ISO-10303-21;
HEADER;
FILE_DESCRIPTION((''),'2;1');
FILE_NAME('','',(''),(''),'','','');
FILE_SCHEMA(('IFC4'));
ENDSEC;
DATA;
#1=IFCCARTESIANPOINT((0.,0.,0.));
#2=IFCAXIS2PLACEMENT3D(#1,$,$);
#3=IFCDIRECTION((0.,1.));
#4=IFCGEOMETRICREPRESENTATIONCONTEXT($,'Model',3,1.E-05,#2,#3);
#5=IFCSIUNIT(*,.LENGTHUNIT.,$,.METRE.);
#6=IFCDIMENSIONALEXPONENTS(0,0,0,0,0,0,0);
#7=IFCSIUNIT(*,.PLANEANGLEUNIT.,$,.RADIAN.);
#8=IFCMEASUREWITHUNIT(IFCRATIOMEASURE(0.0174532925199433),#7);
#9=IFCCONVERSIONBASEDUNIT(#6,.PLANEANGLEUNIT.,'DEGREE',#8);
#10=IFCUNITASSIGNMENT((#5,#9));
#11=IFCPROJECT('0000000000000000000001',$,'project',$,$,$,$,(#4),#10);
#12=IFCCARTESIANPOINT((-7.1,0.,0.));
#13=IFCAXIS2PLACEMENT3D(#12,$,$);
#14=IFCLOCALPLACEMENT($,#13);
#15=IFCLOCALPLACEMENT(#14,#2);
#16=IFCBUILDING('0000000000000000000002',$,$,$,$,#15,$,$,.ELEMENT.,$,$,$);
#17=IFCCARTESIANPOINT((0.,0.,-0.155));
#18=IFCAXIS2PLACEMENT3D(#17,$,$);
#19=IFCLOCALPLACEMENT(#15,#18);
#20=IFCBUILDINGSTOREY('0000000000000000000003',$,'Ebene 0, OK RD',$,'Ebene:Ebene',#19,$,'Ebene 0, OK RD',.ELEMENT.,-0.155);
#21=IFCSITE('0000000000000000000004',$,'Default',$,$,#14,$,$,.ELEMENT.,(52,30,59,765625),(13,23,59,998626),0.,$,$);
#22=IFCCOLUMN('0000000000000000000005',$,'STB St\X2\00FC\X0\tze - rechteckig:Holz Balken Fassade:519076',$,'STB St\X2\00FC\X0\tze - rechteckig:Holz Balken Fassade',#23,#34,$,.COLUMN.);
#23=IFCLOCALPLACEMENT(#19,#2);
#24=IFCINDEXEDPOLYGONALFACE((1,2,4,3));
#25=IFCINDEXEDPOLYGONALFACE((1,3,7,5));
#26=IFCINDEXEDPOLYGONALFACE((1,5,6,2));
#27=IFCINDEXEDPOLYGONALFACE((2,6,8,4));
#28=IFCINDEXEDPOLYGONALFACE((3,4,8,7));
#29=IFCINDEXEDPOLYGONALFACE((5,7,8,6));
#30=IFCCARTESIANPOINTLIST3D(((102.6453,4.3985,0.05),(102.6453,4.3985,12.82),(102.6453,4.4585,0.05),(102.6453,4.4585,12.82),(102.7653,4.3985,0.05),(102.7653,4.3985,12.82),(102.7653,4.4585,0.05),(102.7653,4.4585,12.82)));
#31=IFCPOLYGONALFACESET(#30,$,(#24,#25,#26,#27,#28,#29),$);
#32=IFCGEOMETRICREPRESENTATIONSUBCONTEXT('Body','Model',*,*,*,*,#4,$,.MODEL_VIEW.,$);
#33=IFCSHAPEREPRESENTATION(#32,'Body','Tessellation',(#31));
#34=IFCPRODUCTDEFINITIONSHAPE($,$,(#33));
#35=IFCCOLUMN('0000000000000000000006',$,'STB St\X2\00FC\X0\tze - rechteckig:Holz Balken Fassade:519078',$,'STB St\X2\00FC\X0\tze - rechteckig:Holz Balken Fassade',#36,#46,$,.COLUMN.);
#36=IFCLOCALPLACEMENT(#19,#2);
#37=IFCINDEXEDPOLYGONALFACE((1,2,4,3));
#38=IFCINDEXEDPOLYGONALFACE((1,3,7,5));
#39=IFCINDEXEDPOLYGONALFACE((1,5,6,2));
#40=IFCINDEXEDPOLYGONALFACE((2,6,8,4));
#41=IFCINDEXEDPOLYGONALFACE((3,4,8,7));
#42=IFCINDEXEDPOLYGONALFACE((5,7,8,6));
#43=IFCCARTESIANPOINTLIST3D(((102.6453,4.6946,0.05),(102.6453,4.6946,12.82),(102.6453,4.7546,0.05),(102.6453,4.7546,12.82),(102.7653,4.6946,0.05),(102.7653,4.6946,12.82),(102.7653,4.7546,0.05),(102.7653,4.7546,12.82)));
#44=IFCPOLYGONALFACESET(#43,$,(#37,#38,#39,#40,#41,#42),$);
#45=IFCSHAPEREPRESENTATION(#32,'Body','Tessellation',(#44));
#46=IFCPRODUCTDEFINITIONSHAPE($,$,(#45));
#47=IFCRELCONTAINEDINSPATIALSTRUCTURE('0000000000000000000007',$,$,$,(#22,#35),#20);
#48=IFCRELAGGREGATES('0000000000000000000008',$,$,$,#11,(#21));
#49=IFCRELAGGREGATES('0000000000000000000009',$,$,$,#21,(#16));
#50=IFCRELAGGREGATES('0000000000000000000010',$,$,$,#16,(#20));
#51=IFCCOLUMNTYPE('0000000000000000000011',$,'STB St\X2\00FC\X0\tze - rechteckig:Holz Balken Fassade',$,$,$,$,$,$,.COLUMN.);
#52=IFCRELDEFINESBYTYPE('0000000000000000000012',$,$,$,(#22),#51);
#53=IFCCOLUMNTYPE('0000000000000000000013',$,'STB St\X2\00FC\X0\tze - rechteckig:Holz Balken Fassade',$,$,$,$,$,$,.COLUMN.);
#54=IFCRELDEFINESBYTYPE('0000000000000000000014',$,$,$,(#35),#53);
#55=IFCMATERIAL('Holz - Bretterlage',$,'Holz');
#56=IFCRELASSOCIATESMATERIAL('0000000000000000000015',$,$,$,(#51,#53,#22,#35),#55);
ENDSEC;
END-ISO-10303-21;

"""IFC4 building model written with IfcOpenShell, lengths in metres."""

from ifc_helpers import new_model, entity, si_unit, converted_unit, direction, frame, frame_2d, origin, place, context, subcontext, project, spatial, rectangle, extrude, source, transform, mapped, material, material_profile, profile_set, profile_usage, type_object, type_shapes, element, save


model = new_model("IFC4")

# Units and contexts
model_context = context("Model", 3, precision=1e-05, world=origin(), true_north=direction((0.0, 1.0)))
body_context = subcontext(model_context, "Body", "Model", "MODEL_VIEW")
ifc_project = project(units=[si_unit("LENGTHUNIT", "METRE"), converted_unit("PLANEANGLEUNIT", "DEGREE", entity("IfcRatioMeasure", 0.0174532925199433), si_unit("PLANEANGLEUNIT", "RADIAN"), dimensions=[0, 0, 0, 0, 0, 0, 0])], contexts=[model_context])

# Site, building, storey
site_placement = place(None, frame((-7.1, 0.0, 0.0)))
site = spatial("IfcSite", under=ifc_project, at=site_placement, Name="Default", CompositionType="ELEMENT", RefLatitude=(52, 30, 59, 765625), RefLongitude=(13, 23, 59, 998626), RefElevation=0.0)
building_placement = place(site_placement, origin())
building = spatial("IfcBuilding", under=site, at=building_placement, CompositionType="ELEMENT")
storey_placement = place(building_placement, frame((0.0, 0.0, -0.155)))
storey = spatial("IfcBuildingStorey", under=building, at=storey_placement, Name="Ebene 0, OK RD", ObjectType="Ebene:Ebene", LongName="Ebene 0, OK RD", CompositionType="ELEMENT", Elevation=-0.155)

# Columns
ifc_material = material(Name="Holz - Bretterlage", Category="Holz")
ifc_material_profile = material_profile(ifc_material, rectangle(XDim=0.12, YDim=0.06, at=frame_2d((0.0, 0.0), x_axis=(1.0, 0.0))), Name="Holz Balken Fassade")
ifc_profile_set = profile_set([ifc_material_profile], Name="Holz Balken Fassade")
ifc_profile_usage_1 = profile_usage(ifc_profile_set)
column_type_1 = type_object("IfcColumnType", Name="STB Stütze - rechteckig:Holz Balken Fassade", PredefinedType="COLUMN", material=ifc_profile_set)
shared_shape_1 = source(origin(), body_context, "Body", "SweptSolid", [
    extrude(rectangle(XDim=0.06, YDim=0.12, at=frame_2d((0.0, 0.0), x_axis=(1.0, 0.0))), frame((102.7053, 4.4285, -0.105), z_axis=(0.0, 0.0, 1.0), x_axis=(0.0, -1.0, 0.0)), (0.0, 0.0, 1.0), 12.77),
])
type_shapes(column_type_1, [shared_shape_1])
column_1_placement = place(storey_placement, frame((0.0, 0.0, 0.155)))
element("IfcColumn", 1, at=column_1_placement, inside=storey, type_object=column_type_1, material=ifc_profile_usage_1, Name="STB Stütze - rechteckig:Holz Balken Fassade:519076", ObjectType="STB Stütze - rechteckig:Holz Balken Fassade", PredefinedType="COLUMN", context=body_context, shape_type="MappedRepresentation", body=[
    mapped(shared_shape_1, transform((0.0, 0.0, 0.0), scale=1.0)),
])
ifc_profile_usage_2 = profile_usage(ifc_profile_set)
column_type_2 = type_object("IfcColumnType", Name="STB Stütze - rechteckig:Holz Balken Fassade", PredefinedType="COLUMN", material=ifc_profile_set)
shared_shape_2 = source(origin(), body_context, "Body", "SweptSolid", [
    extrude(rectangle(XDim=0.06, YDim=0.12, at=frame_2d((0.0, 0.0), x_axis=(1.0, 0.0))), frame((102.7053, 4.7246, -0.105), z_axis=(0.0, 0.0, 1.0), x_axis=(0.0, -1.0, 0.0)), (0.0, 0.0, 1.0), 12.77),
])
type_shapes(column_type_2, [shared_shape_2])
column_2_placement = place(storey_placement, frame((0.0, 0.0, 0.155)))
element("IfcColumn", 2, at=column_2_placement, inside=storey, type_object=column_type_2, material=ifc_profile_usage_2, Name="STB Stütze - rechteckig:Holz Balken Fassade:519078", ObjectType="STB Stütze - rechteckig:Holz Balken Fassade", PredefinedType="COLUMN", context=body_context, shape_type="MappedRepresentation", body=[
    mapped(shared_shape_2, transform((0.0, 0.0, 0.0), scale=1.0)),
])

save(model, "model.ifc")
